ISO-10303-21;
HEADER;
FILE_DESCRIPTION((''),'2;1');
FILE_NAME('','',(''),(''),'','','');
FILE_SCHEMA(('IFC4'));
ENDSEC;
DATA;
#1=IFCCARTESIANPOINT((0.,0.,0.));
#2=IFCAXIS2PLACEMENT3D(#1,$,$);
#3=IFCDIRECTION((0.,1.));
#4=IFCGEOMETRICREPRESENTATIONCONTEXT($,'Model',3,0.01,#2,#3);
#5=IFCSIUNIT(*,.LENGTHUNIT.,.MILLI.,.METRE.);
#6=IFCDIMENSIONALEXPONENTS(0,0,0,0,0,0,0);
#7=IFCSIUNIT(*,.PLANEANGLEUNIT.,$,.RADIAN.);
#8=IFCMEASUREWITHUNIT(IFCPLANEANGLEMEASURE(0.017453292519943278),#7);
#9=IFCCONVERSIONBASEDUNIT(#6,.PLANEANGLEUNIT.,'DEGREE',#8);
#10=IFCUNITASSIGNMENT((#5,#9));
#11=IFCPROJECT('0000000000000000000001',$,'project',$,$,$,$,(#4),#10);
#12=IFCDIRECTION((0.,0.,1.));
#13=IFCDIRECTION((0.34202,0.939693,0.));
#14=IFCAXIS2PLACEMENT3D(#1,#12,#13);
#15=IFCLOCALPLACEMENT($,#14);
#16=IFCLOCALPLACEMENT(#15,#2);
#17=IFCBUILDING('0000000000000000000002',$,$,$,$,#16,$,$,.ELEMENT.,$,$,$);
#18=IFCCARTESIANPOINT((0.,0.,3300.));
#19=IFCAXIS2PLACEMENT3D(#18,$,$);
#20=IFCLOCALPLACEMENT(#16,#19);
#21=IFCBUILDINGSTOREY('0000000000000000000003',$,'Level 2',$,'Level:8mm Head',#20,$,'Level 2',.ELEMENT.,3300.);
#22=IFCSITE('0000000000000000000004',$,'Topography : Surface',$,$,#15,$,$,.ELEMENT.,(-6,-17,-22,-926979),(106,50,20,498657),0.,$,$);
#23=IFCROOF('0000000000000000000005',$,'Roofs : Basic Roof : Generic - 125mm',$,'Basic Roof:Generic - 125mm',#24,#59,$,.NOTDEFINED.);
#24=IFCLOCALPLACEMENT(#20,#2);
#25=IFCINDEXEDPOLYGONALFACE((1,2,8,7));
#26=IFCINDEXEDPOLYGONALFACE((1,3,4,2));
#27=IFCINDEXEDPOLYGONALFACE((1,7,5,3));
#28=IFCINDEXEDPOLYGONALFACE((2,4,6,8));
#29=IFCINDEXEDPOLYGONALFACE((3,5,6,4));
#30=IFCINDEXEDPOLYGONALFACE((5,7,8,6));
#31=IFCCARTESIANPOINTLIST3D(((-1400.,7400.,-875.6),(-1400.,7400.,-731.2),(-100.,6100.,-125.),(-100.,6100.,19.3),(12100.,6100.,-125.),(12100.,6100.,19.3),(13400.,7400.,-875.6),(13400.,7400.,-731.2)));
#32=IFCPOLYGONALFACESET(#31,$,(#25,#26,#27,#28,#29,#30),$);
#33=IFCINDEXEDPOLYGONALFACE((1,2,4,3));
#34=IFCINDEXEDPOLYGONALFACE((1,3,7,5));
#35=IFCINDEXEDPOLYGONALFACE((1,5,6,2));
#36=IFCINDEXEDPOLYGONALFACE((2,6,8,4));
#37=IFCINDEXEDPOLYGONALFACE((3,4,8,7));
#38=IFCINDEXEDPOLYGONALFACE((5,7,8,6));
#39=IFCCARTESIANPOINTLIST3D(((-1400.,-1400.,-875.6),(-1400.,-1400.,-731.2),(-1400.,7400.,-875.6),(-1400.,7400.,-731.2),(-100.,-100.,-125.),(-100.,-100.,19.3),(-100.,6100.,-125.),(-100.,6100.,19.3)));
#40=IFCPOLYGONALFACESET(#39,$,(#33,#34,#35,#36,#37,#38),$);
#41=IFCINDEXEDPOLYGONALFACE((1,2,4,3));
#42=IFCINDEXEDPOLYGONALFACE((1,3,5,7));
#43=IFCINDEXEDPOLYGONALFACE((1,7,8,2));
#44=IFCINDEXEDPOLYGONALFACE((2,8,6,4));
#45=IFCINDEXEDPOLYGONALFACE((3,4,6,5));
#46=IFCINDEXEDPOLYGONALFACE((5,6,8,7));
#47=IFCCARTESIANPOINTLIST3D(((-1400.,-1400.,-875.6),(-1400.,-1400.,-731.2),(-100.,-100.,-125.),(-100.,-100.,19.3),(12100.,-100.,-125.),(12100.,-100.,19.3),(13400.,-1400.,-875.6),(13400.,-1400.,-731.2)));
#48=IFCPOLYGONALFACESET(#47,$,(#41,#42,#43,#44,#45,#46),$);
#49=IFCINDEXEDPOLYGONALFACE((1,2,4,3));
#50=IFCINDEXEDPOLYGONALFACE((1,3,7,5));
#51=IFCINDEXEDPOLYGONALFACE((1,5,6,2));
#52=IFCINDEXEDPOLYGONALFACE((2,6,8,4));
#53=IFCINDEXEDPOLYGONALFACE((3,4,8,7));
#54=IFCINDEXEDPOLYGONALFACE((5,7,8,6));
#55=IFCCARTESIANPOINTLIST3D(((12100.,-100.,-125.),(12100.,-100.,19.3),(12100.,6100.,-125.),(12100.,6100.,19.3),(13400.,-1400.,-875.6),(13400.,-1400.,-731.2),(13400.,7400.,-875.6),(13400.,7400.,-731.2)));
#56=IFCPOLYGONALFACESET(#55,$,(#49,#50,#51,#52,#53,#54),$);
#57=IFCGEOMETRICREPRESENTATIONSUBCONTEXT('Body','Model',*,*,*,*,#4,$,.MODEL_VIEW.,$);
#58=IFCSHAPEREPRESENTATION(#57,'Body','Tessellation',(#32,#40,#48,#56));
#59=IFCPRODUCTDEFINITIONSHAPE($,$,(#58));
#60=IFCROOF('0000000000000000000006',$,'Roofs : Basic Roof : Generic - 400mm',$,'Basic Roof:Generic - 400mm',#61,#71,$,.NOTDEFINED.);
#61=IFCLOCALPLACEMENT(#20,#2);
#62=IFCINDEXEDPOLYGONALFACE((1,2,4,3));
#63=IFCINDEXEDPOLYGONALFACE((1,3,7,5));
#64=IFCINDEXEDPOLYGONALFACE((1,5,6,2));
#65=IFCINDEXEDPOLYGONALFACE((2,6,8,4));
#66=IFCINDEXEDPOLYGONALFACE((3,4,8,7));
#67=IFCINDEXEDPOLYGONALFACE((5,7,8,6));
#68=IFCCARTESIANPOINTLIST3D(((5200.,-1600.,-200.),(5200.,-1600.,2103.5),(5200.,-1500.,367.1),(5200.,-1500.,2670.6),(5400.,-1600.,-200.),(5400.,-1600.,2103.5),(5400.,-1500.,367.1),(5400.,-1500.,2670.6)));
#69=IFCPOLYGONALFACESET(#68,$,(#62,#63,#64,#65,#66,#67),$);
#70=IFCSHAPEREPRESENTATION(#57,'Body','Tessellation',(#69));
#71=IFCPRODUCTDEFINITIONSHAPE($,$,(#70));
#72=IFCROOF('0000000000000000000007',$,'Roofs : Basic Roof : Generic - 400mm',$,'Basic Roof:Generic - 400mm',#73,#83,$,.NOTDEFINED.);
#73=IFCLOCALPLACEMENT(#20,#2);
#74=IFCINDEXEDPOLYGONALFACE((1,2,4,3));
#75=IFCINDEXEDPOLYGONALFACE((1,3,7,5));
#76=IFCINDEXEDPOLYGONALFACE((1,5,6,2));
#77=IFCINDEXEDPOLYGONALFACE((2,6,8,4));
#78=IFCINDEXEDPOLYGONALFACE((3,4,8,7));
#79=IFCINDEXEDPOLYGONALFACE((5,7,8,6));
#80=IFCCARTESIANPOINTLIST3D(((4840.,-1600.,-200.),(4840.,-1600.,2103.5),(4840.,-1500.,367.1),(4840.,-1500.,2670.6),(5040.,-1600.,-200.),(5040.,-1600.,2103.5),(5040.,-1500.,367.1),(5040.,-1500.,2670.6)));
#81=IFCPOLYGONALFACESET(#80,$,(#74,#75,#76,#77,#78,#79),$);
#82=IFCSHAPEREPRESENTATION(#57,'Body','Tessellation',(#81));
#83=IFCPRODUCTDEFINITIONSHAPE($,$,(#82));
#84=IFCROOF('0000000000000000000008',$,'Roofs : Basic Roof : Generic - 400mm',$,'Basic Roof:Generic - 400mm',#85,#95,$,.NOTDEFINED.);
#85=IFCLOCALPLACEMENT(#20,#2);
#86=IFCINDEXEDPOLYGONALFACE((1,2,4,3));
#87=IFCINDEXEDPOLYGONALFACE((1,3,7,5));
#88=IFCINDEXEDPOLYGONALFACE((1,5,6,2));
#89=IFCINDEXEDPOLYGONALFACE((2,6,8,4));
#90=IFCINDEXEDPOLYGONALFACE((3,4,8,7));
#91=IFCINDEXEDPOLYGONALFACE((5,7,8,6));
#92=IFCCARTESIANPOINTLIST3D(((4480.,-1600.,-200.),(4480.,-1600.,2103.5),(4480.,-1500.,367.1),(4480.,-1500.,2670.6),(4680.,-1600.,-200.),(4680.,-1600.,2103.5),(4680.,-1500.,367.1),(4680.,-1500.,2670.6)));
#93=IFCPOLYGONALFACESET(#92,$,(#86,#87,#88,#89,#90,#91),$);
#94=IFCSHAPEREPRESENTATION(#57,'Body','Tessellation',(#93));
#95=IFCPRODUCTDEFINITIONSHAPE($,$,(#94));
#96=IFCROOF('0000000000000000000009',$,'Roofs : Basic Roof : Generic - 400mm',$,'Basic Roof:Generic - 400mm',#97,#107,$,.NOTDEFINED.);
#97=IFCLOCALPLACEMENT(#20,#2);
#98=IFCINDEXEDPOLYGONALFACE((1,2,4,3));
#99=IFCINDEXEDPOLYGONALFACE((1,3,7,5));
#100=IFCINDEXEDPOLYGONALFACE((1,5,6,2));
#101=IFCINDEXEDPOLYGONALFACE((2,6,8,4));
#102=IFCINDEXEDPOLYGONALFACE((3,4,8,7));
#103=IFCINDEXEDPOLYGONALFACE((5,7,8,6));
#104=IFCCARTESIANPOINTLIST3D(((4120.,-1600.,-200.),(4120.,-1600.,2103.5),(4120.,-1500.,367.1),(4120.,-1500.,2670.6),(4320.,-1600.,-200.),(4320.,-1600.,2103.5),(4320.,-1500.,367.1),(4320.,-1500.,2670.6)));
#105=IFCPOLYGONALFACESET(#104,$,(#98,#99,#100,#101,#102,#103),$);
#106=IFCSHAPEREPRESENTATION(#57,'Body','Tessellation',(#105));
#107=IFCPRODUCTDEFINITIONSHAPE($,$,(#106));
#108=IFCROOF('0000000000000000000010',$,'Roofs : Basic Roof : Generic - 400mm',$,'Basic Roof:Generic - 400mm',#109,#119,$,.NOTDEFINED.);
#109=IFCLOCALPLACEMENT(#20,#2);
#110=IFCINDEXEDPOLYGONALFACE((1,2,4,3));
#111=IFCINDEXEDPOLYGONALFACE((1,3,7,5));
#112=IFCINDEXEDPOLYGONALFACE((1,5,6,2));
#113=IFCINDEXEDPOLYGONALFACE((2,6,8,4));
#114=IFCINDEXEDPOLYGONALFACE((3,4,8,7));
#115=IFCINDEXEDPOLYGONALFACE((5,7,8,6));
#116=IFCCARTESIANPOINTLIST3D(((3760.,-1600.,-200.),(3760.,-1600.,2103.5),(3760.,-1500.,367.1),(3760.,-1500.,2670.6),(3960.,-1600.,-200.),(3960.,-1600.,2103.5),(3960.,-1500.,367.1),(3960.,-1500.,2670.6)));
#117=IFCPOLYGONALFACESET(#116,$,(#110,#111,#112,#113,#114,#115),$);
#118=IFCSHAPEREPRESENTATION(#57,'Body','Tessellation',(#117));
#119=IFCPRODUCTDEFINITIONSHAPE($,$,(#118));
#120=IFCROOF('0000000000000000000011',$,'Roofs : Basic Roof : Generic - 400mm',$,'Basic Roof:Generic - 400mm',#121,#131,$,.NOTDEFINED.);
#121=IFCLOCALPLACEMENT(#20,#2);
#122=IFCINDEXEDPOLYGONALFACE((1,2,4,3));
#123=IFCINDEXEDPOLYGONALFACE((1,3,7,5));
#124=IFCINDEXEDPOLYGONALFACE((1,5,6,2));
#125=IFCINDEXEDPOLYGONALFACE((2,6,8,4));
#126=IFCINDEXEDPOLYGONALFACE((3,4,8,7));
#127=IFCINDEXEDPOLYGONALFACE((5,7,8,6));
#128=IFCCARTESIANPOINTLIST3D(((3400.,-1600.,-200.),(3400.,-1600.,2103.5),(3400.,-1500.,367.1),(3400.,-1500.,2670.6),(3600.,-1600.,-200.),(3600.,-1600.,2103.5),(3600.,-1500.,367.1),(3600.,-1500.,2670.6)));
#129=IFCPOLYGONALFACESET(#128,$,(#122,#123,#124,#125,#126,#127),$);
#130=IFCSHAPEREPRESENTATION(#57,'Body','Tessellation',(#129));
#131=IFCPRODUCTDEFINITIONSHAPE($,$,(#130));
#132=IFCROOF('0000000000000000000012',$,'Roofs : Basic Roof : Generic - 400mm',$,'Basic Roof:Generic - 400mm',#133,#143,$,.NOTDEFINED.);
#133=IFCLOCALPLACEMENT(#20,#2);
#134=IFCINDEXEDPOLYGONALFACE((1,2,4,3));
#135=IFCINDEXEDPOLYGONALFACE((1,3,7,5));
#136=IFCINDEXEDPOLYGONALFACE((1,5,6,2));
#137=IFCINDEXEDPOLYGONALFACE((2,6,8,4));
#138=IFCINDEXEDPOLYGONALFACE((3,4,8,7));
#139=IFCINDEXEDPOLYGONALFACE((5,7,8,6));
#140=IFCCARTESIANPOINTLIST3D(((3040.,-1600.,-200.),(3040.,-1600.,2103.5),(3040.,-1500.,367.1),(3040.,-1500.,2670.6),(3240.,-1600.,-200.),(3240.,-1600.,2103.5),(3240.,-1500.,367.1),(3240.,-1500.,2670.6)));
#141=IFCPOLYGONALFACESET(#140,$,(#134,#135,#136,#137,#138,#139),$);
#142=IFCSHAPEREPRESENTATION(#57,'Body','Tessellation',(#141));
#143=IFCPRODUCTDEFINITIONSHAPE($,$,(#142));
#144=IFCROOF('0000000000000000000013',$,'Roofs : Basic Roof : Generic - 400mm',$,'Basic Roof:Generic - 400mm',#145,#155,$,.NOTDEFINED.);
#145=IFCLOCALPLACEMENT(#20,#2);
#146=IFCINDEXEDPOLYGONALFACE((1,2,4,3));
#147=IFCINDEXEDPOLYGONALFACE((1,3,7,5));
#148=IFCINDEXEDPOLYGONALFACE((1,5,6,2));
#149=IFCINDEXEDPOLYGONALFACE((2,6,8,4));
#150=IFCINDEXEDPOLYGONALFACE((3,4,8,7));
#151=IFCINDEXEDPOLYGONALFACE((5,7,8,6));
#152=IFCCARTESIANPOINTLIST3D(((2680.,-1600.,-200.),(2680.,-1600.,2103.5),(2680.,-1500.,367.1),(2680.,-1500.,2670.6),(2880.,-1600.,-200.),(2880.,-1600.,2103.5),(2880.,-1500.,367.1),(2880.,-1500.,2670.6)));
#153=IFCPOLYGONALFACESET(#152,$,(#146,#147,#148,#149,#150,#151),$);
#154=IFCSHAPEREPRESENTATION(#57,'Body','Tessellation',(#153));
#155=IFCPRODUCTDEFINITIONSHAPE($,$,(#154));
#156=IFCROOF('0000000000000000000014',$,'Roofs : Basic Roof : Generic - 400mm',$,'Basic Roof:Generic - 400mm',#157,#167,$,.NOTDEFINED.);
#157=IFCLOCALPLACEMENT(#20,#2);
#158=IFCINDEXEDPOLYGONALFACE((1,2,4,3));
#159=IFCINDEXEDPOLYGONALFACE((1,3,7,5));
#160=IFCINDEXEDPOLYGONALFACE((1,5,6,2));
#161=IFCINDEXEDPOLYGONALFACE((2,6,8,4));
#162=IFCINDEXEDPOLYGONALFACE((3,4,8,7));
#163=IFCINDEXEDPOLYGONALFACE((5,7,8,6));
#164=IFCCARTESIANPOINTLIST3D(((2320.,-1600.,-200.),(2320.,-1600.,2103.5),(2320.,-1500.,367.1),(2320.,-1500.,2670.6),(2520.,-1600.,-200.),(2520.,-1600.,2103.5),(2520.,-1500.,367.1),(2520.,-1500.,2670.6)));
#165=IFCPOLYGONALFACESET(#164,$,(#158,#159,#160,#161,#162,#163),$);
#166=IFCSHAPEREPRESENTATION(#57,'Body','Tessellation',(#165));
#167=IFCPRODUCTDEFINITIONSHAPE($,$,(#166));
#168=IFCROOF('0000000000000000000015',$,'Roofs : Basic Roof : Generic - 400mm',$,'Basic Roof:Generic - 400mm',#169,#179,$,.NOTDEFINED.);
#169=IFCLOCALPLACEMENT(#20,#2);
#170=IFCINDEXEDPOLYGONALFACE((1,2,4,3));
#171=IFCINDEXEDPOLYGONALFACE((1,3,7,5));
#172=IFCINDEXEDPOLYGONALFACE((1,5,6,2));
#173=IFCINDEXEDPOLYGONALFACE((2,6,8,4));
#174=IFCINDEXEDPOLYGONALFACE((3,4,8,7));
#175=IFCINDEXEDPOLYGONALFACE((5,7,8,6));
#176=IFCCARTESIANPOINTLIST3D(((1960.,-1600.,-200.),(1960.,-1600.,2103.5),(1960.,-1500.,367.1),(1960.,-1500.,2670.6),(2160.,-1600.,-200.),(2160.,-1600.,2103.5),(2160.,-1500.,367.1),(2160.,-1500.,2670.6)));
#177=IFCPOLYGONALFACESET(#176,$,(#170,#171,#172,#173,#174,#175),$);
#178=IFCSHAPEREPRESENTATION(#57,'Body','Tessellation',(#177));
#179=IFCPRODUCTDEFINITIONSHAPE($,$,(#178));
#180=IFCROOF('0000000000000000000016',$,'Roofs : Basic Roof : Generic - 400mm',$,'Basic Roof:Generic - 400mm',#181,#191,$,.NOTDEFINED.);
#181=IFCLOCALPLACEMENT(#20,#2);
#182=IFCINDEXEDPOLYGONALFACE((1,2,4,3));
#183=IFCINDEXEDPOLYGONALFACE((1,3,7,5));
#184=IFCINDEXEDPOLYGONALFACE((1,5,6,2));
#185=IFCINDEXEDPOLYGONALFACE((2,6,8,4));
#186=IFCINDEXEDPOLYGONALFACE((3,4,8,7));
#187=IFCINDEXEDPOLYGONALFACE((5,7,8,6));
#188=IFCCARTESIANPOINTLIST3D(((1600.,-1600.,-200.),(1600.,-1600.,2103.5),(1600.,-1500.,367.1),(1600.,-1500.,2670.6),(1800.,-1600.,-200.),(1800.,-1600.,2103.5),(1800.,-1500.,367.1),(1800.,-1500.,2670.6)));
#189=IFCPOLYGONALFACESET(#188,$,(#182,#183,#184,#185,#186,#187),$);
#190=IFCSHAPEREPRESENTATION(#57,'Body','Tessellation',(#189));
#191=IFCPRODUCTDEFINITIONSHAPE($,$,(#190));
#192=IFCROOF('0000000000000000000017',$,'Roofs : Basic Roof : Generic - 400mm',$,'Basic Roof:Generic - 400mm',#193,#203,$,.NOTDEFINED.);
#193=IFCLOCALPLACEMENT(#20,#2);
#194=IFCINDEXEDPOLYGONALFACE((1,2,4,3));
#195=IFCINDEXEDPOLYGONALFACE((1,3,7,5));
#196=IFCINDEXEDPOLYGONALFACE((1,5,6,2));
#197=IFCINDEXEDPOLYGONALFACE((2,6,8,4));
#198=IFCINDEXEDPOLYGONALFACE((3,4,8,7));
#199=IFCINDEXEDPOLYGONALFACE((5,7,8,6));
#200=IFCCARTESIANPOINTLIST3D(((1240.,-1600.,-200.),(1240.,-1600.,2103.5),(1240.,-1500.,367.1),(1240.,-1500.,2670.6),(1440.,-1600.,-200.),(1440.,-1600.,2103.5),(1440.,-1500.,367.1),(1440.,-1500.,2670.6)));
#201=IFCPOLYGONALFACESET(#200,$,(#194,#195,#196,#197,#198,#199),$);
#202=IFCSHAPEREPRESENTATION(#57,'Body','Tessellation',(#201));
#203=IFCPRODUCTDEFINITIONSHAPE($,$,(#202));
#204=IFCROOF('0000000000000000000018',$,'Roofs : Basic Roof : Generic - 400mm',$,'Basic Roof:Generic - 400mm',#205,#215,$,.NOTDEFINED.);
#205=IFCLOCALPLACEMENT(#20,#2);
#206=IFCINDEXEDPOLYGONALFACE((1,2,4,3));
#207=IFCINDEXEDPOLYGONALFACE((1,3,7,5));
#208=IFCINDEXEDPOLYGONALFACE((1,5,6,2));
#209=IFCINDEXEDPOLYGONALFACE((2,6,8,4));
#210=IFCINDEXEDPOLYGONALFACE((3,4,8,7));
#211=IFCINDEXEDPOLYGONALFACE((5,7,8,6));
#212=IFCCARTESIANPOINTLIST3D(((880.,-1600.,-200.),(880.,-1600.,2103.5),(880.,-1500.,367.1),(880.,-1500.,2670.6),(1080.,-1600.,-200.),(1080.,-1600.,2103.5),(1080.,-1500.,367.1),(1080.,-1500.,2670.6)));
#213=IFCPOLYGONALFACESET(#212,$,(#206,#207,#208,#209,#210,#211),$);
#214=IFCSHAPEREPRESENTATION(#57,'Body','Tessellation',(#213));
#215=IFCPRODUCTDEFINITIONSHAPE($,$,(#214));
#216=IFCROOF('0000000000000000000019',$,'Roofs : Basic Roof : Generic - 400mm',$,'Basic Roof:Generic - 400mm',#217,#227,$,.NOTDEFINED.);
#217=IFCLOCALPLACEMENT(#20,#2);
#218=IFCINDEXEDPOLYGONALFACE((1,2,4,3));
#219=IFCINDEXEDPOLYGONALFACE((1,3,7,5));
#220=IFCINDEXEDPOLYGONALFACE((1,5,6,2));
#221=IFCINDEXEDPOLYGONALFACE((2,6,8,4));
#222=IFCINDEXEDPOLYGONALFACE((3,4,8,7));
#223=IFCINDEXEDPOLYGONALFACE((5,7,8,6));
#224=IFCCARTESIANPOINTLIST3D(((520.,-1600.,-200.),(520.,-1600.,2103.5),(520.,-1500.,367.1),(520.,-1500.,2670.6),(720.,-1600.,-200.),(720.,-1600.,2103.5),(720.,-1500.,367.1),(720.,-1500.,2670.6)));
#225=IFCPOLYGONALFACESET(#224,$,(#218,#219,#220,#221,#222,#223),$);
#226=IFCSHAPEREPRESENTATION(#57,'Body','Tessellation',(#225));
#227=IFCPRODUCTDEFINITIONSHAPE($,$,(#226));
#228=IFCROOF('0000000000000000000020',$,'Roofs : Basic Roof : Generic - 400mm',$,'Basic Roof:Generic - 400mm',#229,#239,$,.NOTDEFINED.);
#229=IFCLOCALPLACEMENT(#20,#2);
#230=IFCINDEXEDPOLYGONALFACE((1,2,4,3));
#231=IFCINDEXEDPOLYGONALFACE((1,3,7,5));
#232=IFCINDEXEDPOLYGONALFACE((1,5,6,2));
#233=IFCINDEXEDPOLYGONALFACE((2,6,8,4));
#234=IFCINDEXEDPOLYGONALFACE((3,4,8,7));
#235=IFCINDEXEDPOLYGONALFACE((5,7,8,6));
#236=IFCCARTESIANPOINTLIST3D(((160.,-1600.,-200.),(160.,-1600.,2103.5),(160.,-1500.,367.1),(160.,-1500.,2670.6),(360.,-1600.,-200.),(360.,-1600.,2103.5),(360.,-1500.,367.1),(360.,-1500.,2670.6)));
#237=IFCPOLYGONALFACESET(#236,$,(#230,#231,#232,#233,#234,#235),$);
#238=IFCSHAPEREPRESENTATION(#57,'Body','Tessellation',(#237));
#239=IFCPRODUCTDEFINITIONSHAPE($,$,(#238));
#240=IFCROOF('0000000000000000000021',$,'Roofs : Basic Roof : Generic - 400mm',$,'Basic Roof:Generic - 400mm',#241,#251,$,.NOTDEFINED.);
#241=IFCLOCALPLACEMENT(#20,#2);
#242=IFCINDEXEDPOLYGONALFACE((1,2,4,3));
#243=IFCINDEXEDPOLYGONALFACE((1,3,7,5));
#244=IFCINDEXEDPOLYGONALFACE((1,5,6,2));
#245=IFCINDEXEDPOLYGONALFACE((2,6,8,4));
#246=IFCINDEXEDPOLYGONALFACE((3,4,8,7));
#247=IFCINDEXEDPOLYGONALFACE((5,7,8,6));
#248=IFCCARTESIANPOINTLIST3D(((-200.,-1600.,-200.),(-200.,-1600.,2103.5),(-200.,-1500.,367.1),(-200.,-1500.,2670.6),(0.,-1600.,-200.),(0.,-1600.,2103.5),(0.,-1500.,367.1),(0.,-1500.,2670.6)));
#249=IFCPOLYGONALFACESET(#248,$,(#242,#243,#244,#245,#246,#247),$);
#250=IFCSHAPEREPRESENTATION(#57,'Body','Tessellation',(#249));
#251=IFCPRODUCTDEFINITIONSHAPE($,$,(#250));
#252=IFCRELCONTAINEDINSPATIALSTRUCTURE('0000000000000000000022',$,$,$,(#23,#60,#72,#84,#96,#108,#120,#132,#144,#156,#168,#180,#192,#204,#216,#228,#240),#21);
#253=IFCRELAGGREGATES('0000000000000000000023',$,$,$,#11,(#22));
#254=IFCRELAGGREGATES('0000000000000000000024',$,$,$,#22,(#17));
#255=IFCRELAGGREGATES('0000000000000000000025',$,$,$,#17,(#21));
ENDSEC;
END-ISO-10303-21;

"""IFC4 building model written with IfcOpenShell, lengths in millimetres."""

from ifc_helpers import new_model, entity, si_unit, converted_unit, direction, frame, origin, place, context, subcontext, project, spatial, indexed_curve, outline, extrude, element, save


model = new_model("IFC4")

# Units and contexts
model_context = context("Model", 3, precision=0.01, world=origin(), true_north=direction((0.0, 1.0)))
body_context = subcontext(model_context, "Body", "Model", "MODEL_VIEW")
ifc_project = project(units=[si_unit("LENGTHUNIT", "METRE", prefix="MILLI"), converted_unit("PLANEANGLEUNIT", "DEGREE", entity("IfcPlaneAngleMeasure", 0.017453292519943278), si_unit("PLANEANGLEUNIT", "RADIAN"), dimensions=[0, 0, 0, 0, 0, 0, 0])], contexts=[model_context])

# Site, building, storey
site_placement = place(None, frame((0.0, 0.0, 0.0), z_axis=(0.0, 0.0, 1.0), x_axis=(0.34202, 0.939693, 0.0)))
site = spatial("IfcSite", under=ifc_project, at=site_placement, Name="Topography : Surface", CompositionType="ELEMENT", RefLatitude=(-6, -17, -22, -926979), RefLongitude=(106, 50, 20, 498657), RefElevation=0.0)
building_placement = place(site_placement, origin())
building = spatial("IfcBuilding", under=site, at=building_placement, CompositionType="ELEMENT")
storey_placement = place(building_placement, frame((0.0, 0.0, 3300.0)))
storey = spatial("IfcBuildingStorey", under=building, at=storey_placement, Name="Level 2", ObjectType="Level:8mm Head", LongName="Level 2", CompositionType="ELEMENT", Elevation=3300.0)

# Roofs
roof_placement = place(storey_placement, frame((-1400.0, -1400.0, -875.6)))
element("IfcRoof", 1, at=roof_placement, inside=storey, Name="Roofs : Basic Roof : Generic - 125mm", ObjectType="Basic Roof:Generic - 125mm", PredefinedType="NOTDEFINED", context=body_context, shape_type="SweptSolid", body=[
    extrude(outline(indexed_curve([(-7400.0, 750.6), (-6100.0, -750.6), (6100.0, -750.6), (7400.0, 750.6), (-7400.0, 750.6)], self_intersect=False)), frame((7400.0, 8150.0, 375.3), z_axis=(0.0, 0.5, 0.866025), x_axis=(1.0, 0.0, 0.0)), (0.0, -0.5, 0.866025), 144.3),
    extrude(outline(indexed_curve([(-750.6, -4400.0), (750.6, -3100.0), (750.6, 3100.0), (-750.6, 4400.0), (-750.6, -4400.0)], self_intersect=False)), frame((650.0, 4400.0, 375.3), z_axis=(-0.5, 0.0, 0.866025), x_axis=(0.866025, 0.0, 0.5)), (0.5, 0.0, 0.866025), 144.3),
    extrude(outline(indexed_curve([(7400.0, -750.6), (6100.0, 750.6), (-6100.0, 750.6), (-7400.0, -750.6), (7400.0, -750.6)], self_intersect=False)), frame((7400.0, 650.0, 375.3), z_axis=(0.0, -0.5, 0.866025), x_axis=(1.0, 0.0, 0.0)), (0.0, 0.5, 0.866025), 144.3),
    extrude(outline(indexed_curve([(750.6, 4400.0), (-750.6, 3100.0), (-750.6, -3100.0), (750.6, -4400.0), (750.6, 4400.0)], self_intersect=False)), frame((14150.0, 4400.0, 375.3), z_axis=(0.5, 0.0, 0.866025), x_axis=(0.866025, 0.0, -0.5)), (-0.5, 0.0, 0.866025), 144.3),
])
for number, where, name in (
    (2, (5200.0, -1600.0, -200.0), "Roofs : Basic Roof : Generic - 400mm"),
    (3, (4840.0, -1600.0, -200.0), "Roofs : Basic Roof : Generic - 400mm"),
    (4, (4480.0, -1600.0, -200.0), "Roofs : Basic Roof : Generic - 400mm"),
    (5, (4120.0, -1600.0, -200.0), "Roofs : Basic Roof : Generic - 400mm"),
    (6, (3760.0, -1600.0, -200.0), "Roofs : Basic Roof : Generic - 400mm"),
    (7, (3400.0, -1600.0, -200.0), "Roofs : Basic Roof : Generic - 400mm"),
    (8, (3040.0, -1600.0, -200.0), "Roofs : Basic Roof : Generic - 400mm"),
    (9, (2680.0, -1600.0, -200.0), "Roofs : Basic Roof : Generic - 400mm"),
    (10, (2320.0, -1600.0, -200.0), "Roofs : Basic Roof : Generic - 400mm"),
    (11, (1960.0, -1600.0, -200.0), "Roofs : Basic Roof : Generic - 400mm"),
    (12, (1600.0, -1600.0, -200.0), "Roofs : Basic Roof : Generic - 400mm"),
    (13, (1240.0, -1600.0, -200.0), "Roofs : Basic Roof : Generic - 400mm"),
    (14, (880.0, -1600.0, -200.0), "Roofs : Basic Roof : Generic - 400mm"),
    (15, (520.0, -1600.0, -200.0), "Roofs : Basic Roof : Generic - 400mm"),
    (16, (160.0, -1600.0, -200.0), "Roofs : Basic Roof : Generic - 400mm"),
    (17, (-200.0, -1600.0, -200.0), "Roofs : Basic Roof : Generic - 400mm"),
):
    element("IfcRoof", number, at=place(storey_placement, frame(where)), inside=storey, Name=name, ObjectType="Basic Roof:Generic - 400mm", PredefinedType="NOTDEFINED", context=body_context, shape_type="SweptSolid", body=[
        extrude(outline(indexed_curve([(100.0, 287.9), (-100.0, 287.9), (-100.0, -287.9), (100.0, -287.9), (100.0, 287.9)], self_intersect=False)), frame((100.0, 50.0, 283.6), z_axis=(0.0, -0.984808, 0.173648), x_axis=(1.0, 0.0, 0.0)), (0.0, 0.984808, 0.173648), 2303.5),
    ])

save(model, "model.ifc")
